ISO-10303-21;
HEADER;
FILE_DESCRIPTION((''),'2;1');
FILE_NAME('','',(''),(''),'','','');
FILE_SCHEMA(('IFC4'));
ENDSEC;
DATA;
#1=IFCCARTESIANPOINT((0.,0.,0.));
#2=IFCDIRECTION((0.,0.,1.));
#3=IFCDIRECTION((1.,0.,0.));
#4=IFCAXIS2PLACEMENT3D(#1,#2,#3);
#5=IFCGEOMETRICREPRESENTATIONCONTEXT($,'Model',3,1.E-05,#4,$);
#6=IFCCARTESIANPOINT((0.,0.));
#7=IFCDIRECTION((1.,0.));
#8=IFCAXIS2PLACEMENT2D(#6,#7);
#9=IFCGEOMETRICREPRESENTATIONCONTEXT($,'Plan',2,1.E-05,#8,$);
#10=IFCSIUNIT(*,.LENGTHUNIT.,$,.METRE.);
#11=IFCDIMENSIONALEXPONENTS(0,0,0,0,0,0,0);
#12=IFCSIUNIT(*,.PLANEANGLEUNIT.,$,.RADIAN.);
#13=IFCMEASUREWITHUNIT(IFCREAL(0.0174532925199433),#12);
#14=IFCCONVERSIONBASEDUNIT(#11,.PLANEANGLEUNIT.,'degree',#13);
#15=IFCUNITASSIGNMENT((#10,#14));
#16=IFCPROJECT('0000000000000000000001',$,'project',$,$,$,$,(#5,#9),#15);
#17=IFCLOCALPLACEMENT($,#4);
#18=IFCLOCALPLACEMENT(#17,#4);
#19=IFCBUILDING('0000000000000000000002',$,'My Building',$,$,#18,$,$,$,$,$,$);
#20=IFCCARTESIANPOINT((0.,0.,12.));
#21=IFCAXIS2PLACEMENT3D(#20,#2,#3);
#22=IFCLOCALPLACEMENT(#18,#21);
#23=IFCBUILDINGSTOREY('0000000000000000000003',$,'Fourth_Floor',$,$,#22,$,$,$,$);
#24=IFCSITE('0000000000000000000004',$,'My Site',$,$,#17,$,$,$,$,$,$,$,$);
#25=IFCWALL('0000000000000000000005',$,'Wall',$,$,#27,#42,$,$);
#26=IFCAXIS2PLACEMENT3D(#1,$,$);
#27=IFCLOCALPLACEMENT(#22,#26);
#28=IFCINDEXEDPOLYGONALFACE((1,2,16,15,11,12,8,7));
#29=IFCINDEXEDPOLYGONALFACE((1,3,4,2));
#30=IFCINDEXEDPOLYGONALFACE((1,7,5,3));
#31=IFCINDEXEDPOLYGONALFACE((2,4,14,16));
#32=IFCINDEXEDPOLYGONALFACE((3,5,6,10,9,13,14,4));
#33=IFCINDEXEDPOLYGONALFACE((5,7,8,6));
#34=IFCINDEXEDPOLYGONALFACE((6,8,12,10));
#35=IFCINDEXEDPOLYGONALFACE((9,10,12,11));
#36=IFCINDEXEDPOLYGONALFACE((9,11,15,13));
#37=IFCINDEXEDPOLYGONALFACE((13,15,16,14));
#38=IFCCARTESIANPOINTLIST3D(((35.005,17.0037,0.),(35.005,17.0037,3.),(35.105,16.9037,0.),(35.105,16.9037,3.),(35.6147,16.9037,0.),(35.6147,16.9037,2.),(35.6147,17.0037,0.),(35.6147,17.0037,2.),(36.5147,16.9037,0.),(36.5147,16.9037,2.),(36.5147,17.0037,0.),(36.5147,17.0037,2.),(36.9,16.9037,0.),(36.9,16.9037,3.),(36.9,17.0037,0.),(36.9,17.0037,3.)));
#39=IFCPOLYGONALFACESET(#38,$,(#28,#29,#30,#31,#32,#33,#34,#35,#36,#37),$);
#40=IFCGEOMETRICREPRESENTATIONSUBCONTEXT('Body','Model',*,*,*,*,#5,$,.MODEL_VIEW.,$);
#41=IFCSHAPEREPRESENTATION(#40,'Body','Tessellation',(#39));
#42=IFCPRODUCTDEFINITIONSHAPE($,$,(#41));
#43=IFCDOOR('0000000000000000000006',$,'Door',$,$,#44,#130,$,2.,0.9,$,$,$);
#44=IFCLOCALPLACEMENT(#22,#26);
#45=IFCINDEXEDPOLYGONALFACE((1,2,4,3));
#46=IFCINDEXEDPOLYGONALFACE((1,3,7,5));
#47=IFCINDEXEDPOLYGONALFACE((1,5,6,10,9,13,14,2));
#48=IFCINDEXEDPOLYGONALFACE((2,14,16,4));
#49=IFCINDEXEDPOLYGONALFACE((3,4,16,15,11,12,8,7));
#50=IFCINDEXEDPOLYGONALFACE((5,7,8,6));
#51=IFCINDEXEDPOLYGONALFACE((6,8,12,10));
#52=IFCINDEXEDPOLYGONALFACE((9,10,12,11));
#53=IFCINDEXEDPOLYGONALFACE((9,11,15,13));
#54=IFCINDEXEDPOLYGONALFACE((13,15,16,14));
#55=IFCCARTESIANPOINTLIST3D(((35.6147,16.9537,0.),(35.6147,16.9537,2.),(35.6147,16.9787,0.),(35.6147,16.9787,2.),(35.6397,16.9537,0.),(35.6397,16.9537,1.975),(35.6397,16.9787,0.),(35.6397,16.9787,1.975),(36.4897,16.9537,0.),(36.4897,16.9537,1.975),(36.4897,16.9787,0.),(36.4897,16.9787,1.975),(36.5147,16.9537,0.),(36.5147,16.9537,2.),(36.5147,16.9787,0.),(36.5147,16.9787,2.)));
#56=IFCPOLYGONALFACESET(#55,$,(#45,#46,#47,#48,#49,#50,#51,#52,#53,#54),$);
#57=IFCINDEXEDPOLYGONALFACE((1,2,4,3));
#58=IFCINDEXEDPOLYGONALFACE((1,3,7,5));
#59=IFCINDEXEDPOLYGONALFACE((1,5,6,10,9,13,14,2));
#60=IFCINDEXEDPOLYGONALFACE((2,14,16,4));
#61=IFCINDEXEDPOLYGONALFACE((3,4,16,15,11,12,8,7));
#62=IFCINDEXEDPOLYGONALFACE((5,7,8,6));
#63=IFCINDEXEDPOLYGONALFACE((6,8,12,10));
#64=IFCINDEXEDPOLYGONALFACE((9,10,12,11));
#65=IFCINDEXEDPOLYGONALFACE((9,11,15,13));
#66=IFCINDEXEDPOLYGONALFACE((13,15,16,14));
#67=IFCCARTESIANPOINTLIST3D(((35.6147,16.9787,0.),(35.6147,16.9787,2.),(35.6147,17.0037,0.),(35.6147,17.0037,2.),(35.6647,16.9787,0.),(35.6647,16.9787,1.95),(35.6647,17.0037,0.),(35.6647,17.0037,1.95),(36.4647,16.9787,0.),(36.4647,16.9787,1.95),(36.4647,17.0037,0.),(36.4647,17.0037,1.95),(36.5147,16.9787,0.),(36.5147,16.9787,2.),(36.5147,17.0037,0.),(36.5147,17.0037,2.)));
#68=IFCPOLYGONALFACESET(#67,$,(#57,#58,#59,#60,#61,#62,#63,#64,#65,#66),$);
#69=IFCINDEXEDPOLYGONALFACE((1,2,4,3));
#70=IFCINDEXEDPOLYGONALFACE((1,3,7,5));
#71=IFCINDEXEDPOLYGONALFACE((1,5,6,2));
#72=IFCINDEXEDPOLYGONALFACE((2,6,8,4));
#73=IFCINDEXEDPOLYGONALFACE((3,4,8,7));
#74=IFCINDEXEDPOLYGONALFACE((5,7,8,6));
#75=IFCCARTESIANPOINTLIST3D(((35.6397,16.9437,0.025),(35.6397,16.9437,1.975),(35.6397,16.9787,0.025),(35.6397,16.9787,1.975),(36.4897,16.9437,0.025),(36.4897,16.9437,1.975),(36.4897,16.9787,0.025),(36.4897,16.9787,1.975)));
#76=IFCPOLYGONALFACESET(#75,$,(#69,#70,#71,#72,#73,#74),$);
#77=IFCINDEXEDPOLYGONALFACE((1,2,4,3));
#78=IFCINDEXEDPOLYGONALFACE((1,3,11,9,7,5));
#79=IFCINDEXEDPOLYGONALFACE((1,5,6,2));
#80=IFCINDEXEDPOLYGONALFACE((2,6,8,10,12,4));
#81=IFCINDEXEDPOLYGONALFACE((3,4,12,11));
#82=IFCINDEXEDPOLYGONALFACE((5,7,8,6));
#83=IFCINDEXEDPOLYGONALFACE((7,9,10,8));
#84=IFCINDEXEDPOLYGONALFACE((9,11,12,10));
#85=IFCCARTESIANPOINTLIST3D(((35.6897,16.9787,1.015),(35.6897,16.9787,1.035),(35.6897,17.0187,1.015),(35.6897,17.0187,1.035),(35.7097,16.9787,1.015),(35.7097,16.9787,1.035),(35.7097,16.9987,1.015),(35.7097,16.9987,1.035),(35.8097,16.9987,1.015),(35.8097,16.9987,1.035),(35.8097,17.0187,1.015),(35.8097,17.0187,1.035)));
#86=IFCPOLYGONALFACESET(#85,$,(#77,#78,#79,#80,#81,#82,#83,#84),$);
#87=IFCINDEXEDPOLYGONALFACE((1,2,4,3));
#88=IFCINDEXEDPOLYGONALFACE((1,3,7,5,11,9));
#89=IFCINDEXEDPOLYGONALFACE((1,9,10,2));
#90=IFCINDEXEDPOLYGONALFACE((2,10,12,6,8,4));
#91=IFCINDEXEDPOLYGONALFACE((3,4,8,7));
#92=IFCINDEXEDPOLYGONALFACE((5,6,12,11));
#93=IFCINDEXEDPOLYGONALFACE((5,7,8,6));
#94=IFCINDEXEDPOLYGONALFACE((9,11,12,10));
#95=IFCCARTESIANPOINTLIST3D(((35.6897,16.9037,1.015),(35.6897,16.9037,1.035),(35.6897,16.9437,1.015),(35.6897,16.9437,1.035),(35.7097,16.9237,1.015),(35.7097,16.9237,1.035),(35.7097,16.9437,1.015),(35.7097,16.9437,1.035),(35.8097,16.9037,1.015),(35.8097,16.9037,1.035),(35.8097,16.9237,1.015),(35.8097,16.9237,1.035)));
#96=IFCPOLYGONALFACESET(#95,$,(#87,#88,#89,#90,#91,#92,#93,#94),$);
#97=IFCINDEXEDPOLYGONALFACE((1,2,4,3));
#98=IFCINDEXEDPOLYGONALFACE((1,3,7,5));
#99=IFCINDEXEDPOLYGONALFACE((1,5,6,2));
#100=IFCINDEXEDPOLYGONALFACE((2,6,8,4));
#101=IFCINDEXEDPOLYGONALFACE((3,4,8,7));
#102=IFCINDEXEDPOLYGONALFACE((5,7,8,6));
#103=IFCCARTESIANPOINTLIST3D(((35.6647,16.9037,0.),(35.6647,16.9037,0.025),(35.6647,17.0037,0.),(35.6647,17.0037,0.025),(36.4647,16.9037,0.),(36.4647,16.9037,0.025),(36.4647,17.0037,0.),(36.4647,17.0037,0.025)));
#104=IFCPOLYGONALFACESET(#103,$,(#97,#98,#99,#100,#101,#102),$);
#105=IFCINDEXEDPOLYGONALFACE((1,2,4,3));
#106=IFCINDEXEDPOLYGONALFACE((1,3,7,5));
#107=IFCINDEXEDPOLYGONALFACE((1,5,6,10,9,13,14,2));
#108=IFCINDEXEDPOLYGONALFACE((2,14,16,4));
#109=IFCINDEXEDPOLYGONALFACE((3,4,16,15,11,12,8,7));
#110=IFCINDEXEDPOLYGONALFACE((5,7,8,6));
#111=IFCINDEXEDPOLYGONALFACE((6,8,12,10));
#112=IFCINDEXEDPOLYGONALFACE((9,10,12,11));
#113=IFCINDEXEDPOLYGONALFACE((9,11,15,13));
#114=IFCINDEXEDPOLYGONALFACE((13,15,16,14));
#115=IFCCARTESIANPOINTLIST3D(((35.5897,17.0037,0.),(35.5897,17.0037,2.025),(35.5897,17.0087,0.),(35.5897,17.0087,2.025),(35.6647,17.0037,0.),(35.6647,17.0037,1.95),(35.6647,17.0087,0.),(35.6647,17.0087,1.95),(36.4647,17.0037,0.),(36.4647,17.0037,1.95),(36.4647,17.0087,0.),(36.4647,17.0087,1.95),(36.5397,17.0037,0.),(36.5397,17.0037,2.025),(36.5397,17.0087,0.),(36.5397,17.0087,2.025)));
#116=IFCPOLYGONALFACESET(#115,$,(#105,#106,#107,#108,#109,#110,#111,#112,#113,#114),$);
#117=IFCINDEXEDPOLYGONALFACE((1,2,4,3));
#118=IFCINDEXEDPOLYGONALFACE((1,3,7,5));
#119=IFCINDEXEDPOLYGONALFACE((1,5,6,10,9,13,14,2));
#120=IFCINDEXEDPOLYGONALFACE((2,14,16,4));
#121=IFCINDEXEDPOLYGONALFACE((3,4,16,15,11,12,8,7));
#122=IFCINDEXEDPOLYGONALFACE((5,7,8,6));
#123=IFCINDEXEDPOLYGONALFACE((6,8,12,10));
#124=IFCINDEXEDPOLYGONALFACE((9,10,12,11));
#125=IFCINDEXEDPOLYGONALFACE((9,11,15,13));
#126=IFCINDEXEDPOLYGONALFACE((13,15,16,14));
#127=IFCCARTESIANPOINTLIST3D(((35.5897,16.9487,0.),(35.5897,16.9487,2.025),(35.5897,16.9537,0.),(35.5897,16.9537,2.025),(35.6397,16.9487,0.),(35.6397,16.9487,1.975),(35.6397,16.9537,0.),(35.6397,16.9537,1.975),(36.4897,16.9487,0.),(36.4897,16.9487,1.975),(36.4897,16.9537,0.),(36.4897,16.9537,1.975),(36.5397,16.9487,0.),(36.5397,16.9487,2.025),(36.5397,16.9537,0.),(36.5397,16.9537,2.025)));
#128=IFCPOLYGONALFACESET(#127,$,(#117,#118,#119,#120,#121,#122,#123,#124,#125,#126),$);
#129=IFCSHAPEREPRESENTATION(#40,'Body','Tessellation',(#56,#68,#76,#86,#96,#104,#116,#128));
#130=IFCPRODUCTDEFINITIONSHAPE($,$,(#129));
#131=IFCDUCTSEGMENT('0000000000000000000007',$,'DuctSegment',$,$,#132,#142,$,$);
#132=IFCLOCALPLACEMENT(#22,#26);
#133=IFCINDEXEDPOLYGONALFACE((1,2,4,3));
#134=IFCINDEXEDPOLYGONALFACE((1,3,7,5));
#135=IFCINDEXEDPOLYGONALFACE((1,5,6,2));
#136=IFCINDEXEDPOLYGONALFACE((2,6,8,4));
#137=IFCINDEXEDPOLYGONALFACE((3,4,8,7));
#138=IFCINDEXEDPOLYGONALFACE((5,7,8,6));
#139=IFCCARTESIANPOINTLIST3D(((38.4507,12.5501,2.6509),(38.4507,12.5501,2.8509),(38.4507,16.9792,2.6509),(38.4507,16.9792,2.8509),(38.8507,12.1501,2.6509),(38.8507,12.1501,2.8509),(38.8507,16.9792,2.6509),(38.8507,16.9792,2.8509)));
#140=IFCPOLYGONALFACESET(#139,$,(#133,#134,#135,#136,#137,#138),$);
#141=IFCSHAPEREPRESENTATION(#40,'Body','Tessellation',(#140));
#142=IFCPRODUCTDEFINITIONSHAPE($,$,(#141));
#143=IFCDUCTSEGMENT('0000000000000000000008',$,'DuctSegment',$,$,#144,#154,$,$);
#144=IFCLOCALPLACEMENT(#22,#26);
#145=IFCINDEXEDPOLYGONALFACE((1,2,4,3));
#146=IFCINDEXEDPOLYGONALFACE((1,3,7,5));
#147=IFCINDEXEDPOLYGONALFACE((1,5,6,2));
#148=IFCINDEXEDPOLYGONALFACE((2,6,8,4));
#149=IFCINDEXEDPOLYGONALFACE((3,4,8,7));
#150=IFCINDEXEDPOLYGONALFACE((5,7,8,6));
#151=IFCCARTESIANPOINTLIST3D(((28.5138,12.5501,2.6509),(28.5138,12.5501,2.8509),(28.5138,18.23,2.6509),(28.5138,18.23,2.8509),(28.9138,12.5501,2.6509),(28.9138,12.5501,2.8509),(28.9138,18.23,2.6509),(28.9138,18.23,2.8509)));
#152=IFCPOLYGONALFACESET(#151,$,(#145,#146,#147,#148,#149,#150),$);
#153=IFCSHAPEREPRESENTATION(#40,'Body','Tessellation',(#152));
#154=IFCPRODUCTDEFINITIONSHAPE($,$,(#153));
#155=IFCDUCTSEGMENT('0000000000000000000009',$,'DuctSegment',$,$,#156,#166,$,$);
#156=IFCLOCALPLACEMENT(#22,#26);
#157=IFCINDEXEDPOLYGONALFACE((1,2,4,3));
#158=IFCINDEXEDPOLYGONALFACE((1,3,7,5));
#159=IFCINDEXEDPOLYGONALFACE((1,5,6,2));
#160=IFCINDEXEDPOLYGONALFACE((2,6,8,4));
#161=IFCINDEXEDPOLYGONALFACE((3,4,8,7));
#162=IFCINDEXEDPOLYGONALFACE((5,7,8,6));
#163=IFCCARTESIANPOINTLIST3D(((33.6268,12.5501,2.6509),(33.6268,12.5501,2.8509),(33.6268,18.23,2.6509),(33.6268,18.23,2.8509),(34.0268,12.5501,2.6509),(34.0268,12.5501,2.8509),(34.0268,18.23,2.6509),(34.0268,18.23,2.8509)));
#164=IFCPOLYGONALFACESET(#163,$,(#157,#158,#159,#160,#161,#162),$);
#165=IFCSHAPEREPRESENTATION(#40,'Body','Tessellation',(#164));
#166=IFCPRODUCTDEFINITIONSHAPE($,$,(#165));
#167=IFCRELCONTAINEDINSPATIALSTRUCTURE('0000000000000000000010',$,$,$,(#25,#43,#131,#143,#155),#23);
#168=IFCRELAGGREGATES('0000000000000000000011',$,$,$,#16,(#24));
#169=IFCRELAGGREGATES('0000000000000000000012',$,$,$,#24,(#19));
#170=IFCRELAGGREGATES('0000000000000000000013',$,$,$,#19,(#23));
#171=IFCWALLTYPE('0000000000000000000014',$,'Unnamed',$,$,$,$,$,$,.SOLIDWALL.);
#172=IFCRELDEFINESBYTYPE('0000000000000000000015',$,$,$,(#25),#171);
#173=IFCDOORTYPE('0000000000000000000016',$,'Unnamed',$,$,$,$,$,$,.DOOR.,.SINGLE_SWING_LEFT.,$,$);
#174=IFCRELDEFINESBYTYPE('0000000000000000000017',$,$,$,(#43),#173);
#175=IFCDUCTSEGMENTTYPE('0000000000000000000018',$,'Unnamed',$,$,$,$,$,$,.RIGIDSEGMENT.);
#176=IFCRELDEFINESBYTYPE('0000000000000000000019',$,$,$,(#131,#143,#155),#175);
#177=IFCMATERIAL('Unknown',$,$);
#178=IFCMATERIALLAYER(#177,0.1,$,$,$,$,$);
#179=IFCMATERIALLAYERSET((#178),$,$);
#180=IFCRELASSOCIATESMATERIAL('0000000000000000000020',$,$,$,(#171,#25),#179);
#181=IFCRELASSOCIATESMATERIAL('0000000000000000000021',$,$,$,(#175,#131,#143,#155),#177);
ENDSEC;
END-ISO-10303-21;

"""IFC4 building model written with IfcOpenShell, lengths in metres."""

from ifc_helpers import new_model, entity, si_unit, converted_unit, frame, origin_with_axes, origin_2d_with_axis, place, context, subcontext, project, spatial, line, indexed_curve, rectangle, outline, extrude, clip, halfspace, shape, source, transform, mapped, material, layer, layer_set, layer_usage, material_profile, profile_set, profile_usage, type_object, type_shapes, element, fill, save


model = new_model("IFC4")

# Units and contexts
model_context = context("Model", 3, precision=1e-05, world=origin_with_axes())
plan_context = context("Plan", 2, precision=1e-05, world=origin_2d_with_axis())
body_context_1 = subcontext(model_context, "Body", "Model", "MODEL_VIEW")
body_context_2 = subcontext(plan_context, "Body", "Plan", "PLAN_VIEW")
ifc_project = project(units=[si_unit("LENGTHUNIT", "METRE"), converted_unit("PLANEANGLEUNIT", "degree", entity("IfcReal", 0.0174532925199433), si_unit("PLANEANGLEUNIT", "RADIAN"), dimensions=[0, 0, 0, 0, 0, 0, 0])], contexts=[model_context, plan_context])

# Site, building, storey
site_placement = place(None, origin_with_axes())
site = spatial("IfcSite", under=ifc_project, at=site_placement, Name="My Site")
building_placement = place(site_placement, origin_with_axes())
building = spatial("IfcBuilding", under=site, at=building_placement, Name="My Building")
storey_placement = place(building_placement, frame((0.0, 0.0, 12.0), z_axis=(0.0, 0.0, 1.0), x_axis=(1.0, 0.0, 0.0)))
storey = spatial("IfcBuildingStorey", under=building, at=storey_placement, Name="Fourth_Floor")

# Shared definitions
ifc_material = material(Name="Unknown")
ifc_layer = layer(ifc_material, 0.1)
ifc_layer_set = layer_set([ifc_layer])
wall_type = type_object("IfcWallType", Name="Unnamed", PredefinedType="SOLIDWALL", material=ifc_layer_set)

# Shared definitions
shared_shape_1 = source(origin_with_axes(), body_context_1, "Body", "SweptSolid", [
    extrude(outline(indexed_curve([(0.0, 0.0), (0.9, 0.0), (0.9, 2.0), (0.0, 2.0)], segments=[line(1, 2, 3, 4, 1)])), frame((0.0, -0.6, 0.0), z_axis=(0.0, -1.0, 0.0), x_axis=(1.0, 0.0, 0.0)), (0.0, 0.0, -1.0), 1.2),
])
door_type = type_object("IfcDoorType", Name="Unnamed", OperationType="SINGLE_SWING_LEFT", PredefinedType="DOOR")
shared_shape_2 = source(origin_with_axes(), body_context_1, "Body", "SweptSolid", [
    extrude(outline(indexed_curve([(0.0, 0.0), (0.0, 2.0), (0.9, 2.0), (0.9, 0.0), (0.875, 0.0), (0.875, 1.975), (0.025, 1.975), (0.025, 0.0)], segments=[line(1, 2, 3, 4, 5, 6, 7, 8, 1)])), frame((0.0, 0.025, 0.0), z_axis=(0.0, -1.0, 0.0), x_axis=(1.0, 0.0, 0.0)), (0.0, 0.0, -1.0), 0.025),
    extrude(outline(indexed_curve([(0.0, 0.0), (0.0, 2.0), (0.9, 2.0), (0.9, 0.0), (0.85, 0.0), (0.85, 1.95), (0.05, 1.95), (0.05, 0.0)], segments=[line(1, 2, 3, 4, 5, 6, 7, 8, 1)])), frame((0.0, 0.0, 0.0), z_axis=(0.0, -1.0, 0.0), x_axis=(1.0, 0.0, 0.0)), (0.0, 0.0, -1.0), 0.025),
    extrude(outline(indexed_curve([(0.0, 0.0), (0.85, 0.0), (0.85, 0.035), (0.0, 0.035)], segments=[line(1, 2, 3, 4, 1)])), frame((0.025, 0.025, 0.025), z_axis=(0.0, 0.0, 1.0), x_axis=(1.0, 0.0, 0.0)), (0.0, 0.0, 1.0), 1.95),
    extrude(outline(indexed_curve([(0.0, 0.0), (0.0, -0.04), (-0.12, -0.04), (-0.12, -0.02), (-0.02, -0.02), (-0.02, 0.0)], segments=[line(1, 2, 3, 4, 5, 6, 1)])), frame((0.825, 0.025, 1.015), z_axis=(0.0, 0.0, 1.0), x_axis=(1.0, 0.0, 0.0)), (0.0, 0.0, 1.0), 0.02),
    extrude(outline(indexed_curve([(0.0, 0.0), (0.0, 0.04), (-0.12, 0.04), (-0.12, 0.02), (-0.02, 0.02), (-0.02, 0.0)], segments=[line(1, 2, 3, 4, 5, 6, 1)])), frame((0.825, 0.06, 1.015), z_axis=(0.0, 0.0, 1.0), x_axis=(1.0, 0.0, 0.0)), (0.0, 0.0, 1.0), 0.02),
    extrude(outline(indexed_curve([(0.0, 0.0), (0.8, 0.0), (0.8, 0.1), (0.0, 0.1)], segments=[line(1, 2, 3, 4, 1)])), frame((0.05, 0.0, 0.0), z_axis=(0.0, 0.0, 1.0), x_axis=(1.0, 0.0, 0.0)), (0.0, 0.0, 1.0), 0.025),
    extrude(outline(indexed_curve([(0.0, 0.0), (0.0, 2.025), (0.95, 2.025), (0.95, 0.0), (0.875, 0.0), (0.875, 1.95), (0.075, 1.95), (0.075, 0.0)], segments=[line(1, 2, 3, 4, 5, 6, 7, 8, 1)])), frame((-0.025, -0.005, 0.0), z_axis=(0.0, -1.0, 0.0), x_axis=(1.0, 0.0, 0.0)), (0.0, 0.0, -1.0), 0.005),
    extrude(outline(indexed_curve([(0.0, 0.0), (0.0, 2.025), (0.95, 2.025), (0.95, 0.0), (0.9, 0.0), (0.9, 1.975), (0.05, 1.975), (0.05, 0.0)], segments=[line(1, 2, 3, 4, 5, 6, 7, 8, 1)])), frame((-0.025, 0.05, 0.0), z_axis=(0.0, -1.0, 0.0), x_axis=(1.0, 0.0, 0.0)), (0.0, 0.0, -1.0), 0.005),
])
shared_shape_3 = source(origin_with_axes(), body_context_2, "Body", "Curve2D", [
    entity("IfcIndexedPolyCurve", entity("IfcCartesianPointList2D", [[0.0, 0.0], [0.0, 0.05], [0.025, 0.05], [0.025, 0.025], [0.05, 0.025], [0.05, 0.0]]), [entity("IfcLineIndex", [1, 2, 3, 4, 5, 6, 1])]),
    entity("IfcIndexedPolyCurve", entity("IfcCartesianPointList2D", [[0.9, 0.0], [0.9, 0.05], [0.875, 0.05], [0.875, 0.025], [0.85, 0.025], [0.85, 0.0]]), [entity("IfcLineIndex", [1, 2, 3, 4, 5, 6, 1])]),
    entity("IfcTrimmedCurve", entity("IfcEllipse", entity("IfcAxis2Placement2D", entity("IfcCartesianPoint", [0.06, 0.05]), entity("IfcDirection", [1.0, 0.0])), 0.815, 0.85), [entity("IfcCartesianPoint", [0.875, 0.05])], [entity("IfcCartesianPoint", [0.06, 0.9])], True, "CARTESIAN"),
    entity("IfcIndexedPolyCurve", entity("IfcCartesianPointList2D", [[0.025, 0.05], [0.06, 0.05], [0.06, 0.9], [0.025, 0.9]]), [entity("IfcLineIndex", [1, 2, 3, 4, 1])]),
])
type_shapes(door_type, [shared_shape_2, shared_shape_3])

# Wall, opening, door
ifc_layer_usage_1 = layer_usage(ifc_layer_set, "AXIS2", "POSITIVE", 0.0)
wall_1_placement = place(storey_placement, frame((36.9, 17.0037, 0.0), z_axis=(0.0, 0.0, 1.0), x_axis=(-1.0, 0.0, 0.0)))
wall_1 = element("IfcWall", 1, at=wall_1_placement, inside=storey, type_object=wall_type, material=ifc_layer_usage_1, Name="Wall", context=body_context_1, shape_type="SweptSolid", body=[
    extrude(outline(indexed_curve([(0.0, 0.0), (0.0, 0.1), (1.795, 0.1), (1.895, 0.0)], segments=[line(1, 2, 3, 4, 1)])), origin_with_axes(), (0.0, 0.0, 1.0), 3.0),
])
opening_1_placement = place(wall_1_placement, frame((0.3853, 0.0, 0.0), z_axis=(0.0, 0.0, 1.0), x_axis=(1.0, 0.0, 0.0)))
opening_1 = element("IfcOpeningElement", 2, at=opening_1_placement, cuts=wall_1, PredefinedType="OPENING", context=body_context_1, shape_type="MappedRepresentation", body=[
    mapped(shared_shape_1, transform((0.0, 0.0, 0.0), x_axis=(1.0, 0.0, 0.0), y_axis=(0.0, 1.0, 0.0), z_axis=(0.0, 0.0, 1.0), scale=1.0)),
])
door_1_placement = place(opening_1_placement, frame((0.0, 0.0, 0.0), z_axis=(0.0, 0.0, 1.0), x_axis=(1.0, 0.0, 0.0)))
door_1 = element("IfcDoor", 3, at=door_1_placement, inside=storey, type_object=door_type, Name="Door", OverallHeight=2.0, OverallWidth=0.9, shapes=[
    shape(body_context_1, "Body", "MappedRepresentation", [mapped(shared_shape_2, transform((0.0, 0.0, 0.0), x_axis=(1.0, 0.0, 0.0), y_axis=(0.0, 1.0, 0.0), z_axis=(0.0, 0.0, 1.0), scale=1.0))]),
    shape(body_context_2, "Body", "MappedRepresentation", [mapped(shared_shape_3, transform((0.0, 0.0, 0.0), x_axis=(1.0, 0.0, 0.0), y_axis=(0.0, 1.0, 0.0), z_axis=(0.0, 0.0, 1.0), scale=1.0))]),
])
fill(opening_1, door_1)

# Duct segments
ifc_material_profile_1 = material_profile(ifc_material, rectangle(XDim=0.4, YDim=0.2))
ifc_profile_set_1 = profile_set([ifc_material_profile_1])
ifc_profile_usage_1 = profile_usage(ifc_profile_set_1, cardinal=5)
duct_segment_type = type_object("IfcDuctSegmentType", Name="Unnamed", PredefinedType="RIGIDSEGMENT", material=ifc_profile_set_1)
duct_segment_1_placement = place(storey_placement, frame((38.6507, 12.1501, 2.7509), z_axis=(0.0, 1.0, 0.0), x_axis=(-1.0, 0.0, 0.0)))
element("IfcDuctSegment", 4, at=duct_segment_1_placement, inside=storey, type_object=duct_segment_type, material=ifc_profile_usage_1, Name="DuctSegment", context=body_context_1, shape_type="Clipping", body=[
    clip(extrude(rectangle(XDim=0.4, YDim=0.2), origin_with_axes(), (0.0, 0.0, 1.0), 4.8291), halfspace(frame((-0.2, -3.0, 0.0), z_axis=(0.707106, 0.0, -0.707109), x_axis=(0.0, -1.0, 0.0)), False)),
])
ifc_profile_usage_2 = profile_usage(ifc_profile_set_1, cardinal=5)
duct_segment_2_placement = place(storey_placement, frame((28.7138, 12.5501, 2.7509), z_axis=(0.0, 1.0, 0.0), x_axis=(-1.0, 0.0, 0.0)))
element("IfcDuctSegment", 5, at=duct_segment_2_placement, inside=storey, type_object=duct_segment_type, material=ifc_profile_usage_2, Name="DuctSegment", context=body_context_1, shape_type="SweptSolid", body=[
    extrude(rectangle(XDim=0.4, YDim=0.2), origin_with_axes(), (0.0, 0.0, 1.0), 5.6799),
])
ifc_profile_usage_3 = profile_usage(ifc_profile_set_1, cardinal=5)
duct_segment_3_placement = place(storey_placement, frame((33.8268, 12.5501, 2.7509), z_axis=(0.0, 1.0, 0.0), x_axis=(-1.0, 0.0, 0.0)))
element("IfcDuctSegment", 6, at=duct_segment_3_placement, inside=storey, type_object=duct_segment_type, material=ifc_profile_usage_3, Name="DuctSegment", context=body_context_1, shape_type="SweptSolid", body=[
    extrude(rectangle(XDim=0.4, YDim=0.2), origin_with_axes(), (0.0, 0.0, 1.0), 5.6799),
])

save(model, "model.ifc")
